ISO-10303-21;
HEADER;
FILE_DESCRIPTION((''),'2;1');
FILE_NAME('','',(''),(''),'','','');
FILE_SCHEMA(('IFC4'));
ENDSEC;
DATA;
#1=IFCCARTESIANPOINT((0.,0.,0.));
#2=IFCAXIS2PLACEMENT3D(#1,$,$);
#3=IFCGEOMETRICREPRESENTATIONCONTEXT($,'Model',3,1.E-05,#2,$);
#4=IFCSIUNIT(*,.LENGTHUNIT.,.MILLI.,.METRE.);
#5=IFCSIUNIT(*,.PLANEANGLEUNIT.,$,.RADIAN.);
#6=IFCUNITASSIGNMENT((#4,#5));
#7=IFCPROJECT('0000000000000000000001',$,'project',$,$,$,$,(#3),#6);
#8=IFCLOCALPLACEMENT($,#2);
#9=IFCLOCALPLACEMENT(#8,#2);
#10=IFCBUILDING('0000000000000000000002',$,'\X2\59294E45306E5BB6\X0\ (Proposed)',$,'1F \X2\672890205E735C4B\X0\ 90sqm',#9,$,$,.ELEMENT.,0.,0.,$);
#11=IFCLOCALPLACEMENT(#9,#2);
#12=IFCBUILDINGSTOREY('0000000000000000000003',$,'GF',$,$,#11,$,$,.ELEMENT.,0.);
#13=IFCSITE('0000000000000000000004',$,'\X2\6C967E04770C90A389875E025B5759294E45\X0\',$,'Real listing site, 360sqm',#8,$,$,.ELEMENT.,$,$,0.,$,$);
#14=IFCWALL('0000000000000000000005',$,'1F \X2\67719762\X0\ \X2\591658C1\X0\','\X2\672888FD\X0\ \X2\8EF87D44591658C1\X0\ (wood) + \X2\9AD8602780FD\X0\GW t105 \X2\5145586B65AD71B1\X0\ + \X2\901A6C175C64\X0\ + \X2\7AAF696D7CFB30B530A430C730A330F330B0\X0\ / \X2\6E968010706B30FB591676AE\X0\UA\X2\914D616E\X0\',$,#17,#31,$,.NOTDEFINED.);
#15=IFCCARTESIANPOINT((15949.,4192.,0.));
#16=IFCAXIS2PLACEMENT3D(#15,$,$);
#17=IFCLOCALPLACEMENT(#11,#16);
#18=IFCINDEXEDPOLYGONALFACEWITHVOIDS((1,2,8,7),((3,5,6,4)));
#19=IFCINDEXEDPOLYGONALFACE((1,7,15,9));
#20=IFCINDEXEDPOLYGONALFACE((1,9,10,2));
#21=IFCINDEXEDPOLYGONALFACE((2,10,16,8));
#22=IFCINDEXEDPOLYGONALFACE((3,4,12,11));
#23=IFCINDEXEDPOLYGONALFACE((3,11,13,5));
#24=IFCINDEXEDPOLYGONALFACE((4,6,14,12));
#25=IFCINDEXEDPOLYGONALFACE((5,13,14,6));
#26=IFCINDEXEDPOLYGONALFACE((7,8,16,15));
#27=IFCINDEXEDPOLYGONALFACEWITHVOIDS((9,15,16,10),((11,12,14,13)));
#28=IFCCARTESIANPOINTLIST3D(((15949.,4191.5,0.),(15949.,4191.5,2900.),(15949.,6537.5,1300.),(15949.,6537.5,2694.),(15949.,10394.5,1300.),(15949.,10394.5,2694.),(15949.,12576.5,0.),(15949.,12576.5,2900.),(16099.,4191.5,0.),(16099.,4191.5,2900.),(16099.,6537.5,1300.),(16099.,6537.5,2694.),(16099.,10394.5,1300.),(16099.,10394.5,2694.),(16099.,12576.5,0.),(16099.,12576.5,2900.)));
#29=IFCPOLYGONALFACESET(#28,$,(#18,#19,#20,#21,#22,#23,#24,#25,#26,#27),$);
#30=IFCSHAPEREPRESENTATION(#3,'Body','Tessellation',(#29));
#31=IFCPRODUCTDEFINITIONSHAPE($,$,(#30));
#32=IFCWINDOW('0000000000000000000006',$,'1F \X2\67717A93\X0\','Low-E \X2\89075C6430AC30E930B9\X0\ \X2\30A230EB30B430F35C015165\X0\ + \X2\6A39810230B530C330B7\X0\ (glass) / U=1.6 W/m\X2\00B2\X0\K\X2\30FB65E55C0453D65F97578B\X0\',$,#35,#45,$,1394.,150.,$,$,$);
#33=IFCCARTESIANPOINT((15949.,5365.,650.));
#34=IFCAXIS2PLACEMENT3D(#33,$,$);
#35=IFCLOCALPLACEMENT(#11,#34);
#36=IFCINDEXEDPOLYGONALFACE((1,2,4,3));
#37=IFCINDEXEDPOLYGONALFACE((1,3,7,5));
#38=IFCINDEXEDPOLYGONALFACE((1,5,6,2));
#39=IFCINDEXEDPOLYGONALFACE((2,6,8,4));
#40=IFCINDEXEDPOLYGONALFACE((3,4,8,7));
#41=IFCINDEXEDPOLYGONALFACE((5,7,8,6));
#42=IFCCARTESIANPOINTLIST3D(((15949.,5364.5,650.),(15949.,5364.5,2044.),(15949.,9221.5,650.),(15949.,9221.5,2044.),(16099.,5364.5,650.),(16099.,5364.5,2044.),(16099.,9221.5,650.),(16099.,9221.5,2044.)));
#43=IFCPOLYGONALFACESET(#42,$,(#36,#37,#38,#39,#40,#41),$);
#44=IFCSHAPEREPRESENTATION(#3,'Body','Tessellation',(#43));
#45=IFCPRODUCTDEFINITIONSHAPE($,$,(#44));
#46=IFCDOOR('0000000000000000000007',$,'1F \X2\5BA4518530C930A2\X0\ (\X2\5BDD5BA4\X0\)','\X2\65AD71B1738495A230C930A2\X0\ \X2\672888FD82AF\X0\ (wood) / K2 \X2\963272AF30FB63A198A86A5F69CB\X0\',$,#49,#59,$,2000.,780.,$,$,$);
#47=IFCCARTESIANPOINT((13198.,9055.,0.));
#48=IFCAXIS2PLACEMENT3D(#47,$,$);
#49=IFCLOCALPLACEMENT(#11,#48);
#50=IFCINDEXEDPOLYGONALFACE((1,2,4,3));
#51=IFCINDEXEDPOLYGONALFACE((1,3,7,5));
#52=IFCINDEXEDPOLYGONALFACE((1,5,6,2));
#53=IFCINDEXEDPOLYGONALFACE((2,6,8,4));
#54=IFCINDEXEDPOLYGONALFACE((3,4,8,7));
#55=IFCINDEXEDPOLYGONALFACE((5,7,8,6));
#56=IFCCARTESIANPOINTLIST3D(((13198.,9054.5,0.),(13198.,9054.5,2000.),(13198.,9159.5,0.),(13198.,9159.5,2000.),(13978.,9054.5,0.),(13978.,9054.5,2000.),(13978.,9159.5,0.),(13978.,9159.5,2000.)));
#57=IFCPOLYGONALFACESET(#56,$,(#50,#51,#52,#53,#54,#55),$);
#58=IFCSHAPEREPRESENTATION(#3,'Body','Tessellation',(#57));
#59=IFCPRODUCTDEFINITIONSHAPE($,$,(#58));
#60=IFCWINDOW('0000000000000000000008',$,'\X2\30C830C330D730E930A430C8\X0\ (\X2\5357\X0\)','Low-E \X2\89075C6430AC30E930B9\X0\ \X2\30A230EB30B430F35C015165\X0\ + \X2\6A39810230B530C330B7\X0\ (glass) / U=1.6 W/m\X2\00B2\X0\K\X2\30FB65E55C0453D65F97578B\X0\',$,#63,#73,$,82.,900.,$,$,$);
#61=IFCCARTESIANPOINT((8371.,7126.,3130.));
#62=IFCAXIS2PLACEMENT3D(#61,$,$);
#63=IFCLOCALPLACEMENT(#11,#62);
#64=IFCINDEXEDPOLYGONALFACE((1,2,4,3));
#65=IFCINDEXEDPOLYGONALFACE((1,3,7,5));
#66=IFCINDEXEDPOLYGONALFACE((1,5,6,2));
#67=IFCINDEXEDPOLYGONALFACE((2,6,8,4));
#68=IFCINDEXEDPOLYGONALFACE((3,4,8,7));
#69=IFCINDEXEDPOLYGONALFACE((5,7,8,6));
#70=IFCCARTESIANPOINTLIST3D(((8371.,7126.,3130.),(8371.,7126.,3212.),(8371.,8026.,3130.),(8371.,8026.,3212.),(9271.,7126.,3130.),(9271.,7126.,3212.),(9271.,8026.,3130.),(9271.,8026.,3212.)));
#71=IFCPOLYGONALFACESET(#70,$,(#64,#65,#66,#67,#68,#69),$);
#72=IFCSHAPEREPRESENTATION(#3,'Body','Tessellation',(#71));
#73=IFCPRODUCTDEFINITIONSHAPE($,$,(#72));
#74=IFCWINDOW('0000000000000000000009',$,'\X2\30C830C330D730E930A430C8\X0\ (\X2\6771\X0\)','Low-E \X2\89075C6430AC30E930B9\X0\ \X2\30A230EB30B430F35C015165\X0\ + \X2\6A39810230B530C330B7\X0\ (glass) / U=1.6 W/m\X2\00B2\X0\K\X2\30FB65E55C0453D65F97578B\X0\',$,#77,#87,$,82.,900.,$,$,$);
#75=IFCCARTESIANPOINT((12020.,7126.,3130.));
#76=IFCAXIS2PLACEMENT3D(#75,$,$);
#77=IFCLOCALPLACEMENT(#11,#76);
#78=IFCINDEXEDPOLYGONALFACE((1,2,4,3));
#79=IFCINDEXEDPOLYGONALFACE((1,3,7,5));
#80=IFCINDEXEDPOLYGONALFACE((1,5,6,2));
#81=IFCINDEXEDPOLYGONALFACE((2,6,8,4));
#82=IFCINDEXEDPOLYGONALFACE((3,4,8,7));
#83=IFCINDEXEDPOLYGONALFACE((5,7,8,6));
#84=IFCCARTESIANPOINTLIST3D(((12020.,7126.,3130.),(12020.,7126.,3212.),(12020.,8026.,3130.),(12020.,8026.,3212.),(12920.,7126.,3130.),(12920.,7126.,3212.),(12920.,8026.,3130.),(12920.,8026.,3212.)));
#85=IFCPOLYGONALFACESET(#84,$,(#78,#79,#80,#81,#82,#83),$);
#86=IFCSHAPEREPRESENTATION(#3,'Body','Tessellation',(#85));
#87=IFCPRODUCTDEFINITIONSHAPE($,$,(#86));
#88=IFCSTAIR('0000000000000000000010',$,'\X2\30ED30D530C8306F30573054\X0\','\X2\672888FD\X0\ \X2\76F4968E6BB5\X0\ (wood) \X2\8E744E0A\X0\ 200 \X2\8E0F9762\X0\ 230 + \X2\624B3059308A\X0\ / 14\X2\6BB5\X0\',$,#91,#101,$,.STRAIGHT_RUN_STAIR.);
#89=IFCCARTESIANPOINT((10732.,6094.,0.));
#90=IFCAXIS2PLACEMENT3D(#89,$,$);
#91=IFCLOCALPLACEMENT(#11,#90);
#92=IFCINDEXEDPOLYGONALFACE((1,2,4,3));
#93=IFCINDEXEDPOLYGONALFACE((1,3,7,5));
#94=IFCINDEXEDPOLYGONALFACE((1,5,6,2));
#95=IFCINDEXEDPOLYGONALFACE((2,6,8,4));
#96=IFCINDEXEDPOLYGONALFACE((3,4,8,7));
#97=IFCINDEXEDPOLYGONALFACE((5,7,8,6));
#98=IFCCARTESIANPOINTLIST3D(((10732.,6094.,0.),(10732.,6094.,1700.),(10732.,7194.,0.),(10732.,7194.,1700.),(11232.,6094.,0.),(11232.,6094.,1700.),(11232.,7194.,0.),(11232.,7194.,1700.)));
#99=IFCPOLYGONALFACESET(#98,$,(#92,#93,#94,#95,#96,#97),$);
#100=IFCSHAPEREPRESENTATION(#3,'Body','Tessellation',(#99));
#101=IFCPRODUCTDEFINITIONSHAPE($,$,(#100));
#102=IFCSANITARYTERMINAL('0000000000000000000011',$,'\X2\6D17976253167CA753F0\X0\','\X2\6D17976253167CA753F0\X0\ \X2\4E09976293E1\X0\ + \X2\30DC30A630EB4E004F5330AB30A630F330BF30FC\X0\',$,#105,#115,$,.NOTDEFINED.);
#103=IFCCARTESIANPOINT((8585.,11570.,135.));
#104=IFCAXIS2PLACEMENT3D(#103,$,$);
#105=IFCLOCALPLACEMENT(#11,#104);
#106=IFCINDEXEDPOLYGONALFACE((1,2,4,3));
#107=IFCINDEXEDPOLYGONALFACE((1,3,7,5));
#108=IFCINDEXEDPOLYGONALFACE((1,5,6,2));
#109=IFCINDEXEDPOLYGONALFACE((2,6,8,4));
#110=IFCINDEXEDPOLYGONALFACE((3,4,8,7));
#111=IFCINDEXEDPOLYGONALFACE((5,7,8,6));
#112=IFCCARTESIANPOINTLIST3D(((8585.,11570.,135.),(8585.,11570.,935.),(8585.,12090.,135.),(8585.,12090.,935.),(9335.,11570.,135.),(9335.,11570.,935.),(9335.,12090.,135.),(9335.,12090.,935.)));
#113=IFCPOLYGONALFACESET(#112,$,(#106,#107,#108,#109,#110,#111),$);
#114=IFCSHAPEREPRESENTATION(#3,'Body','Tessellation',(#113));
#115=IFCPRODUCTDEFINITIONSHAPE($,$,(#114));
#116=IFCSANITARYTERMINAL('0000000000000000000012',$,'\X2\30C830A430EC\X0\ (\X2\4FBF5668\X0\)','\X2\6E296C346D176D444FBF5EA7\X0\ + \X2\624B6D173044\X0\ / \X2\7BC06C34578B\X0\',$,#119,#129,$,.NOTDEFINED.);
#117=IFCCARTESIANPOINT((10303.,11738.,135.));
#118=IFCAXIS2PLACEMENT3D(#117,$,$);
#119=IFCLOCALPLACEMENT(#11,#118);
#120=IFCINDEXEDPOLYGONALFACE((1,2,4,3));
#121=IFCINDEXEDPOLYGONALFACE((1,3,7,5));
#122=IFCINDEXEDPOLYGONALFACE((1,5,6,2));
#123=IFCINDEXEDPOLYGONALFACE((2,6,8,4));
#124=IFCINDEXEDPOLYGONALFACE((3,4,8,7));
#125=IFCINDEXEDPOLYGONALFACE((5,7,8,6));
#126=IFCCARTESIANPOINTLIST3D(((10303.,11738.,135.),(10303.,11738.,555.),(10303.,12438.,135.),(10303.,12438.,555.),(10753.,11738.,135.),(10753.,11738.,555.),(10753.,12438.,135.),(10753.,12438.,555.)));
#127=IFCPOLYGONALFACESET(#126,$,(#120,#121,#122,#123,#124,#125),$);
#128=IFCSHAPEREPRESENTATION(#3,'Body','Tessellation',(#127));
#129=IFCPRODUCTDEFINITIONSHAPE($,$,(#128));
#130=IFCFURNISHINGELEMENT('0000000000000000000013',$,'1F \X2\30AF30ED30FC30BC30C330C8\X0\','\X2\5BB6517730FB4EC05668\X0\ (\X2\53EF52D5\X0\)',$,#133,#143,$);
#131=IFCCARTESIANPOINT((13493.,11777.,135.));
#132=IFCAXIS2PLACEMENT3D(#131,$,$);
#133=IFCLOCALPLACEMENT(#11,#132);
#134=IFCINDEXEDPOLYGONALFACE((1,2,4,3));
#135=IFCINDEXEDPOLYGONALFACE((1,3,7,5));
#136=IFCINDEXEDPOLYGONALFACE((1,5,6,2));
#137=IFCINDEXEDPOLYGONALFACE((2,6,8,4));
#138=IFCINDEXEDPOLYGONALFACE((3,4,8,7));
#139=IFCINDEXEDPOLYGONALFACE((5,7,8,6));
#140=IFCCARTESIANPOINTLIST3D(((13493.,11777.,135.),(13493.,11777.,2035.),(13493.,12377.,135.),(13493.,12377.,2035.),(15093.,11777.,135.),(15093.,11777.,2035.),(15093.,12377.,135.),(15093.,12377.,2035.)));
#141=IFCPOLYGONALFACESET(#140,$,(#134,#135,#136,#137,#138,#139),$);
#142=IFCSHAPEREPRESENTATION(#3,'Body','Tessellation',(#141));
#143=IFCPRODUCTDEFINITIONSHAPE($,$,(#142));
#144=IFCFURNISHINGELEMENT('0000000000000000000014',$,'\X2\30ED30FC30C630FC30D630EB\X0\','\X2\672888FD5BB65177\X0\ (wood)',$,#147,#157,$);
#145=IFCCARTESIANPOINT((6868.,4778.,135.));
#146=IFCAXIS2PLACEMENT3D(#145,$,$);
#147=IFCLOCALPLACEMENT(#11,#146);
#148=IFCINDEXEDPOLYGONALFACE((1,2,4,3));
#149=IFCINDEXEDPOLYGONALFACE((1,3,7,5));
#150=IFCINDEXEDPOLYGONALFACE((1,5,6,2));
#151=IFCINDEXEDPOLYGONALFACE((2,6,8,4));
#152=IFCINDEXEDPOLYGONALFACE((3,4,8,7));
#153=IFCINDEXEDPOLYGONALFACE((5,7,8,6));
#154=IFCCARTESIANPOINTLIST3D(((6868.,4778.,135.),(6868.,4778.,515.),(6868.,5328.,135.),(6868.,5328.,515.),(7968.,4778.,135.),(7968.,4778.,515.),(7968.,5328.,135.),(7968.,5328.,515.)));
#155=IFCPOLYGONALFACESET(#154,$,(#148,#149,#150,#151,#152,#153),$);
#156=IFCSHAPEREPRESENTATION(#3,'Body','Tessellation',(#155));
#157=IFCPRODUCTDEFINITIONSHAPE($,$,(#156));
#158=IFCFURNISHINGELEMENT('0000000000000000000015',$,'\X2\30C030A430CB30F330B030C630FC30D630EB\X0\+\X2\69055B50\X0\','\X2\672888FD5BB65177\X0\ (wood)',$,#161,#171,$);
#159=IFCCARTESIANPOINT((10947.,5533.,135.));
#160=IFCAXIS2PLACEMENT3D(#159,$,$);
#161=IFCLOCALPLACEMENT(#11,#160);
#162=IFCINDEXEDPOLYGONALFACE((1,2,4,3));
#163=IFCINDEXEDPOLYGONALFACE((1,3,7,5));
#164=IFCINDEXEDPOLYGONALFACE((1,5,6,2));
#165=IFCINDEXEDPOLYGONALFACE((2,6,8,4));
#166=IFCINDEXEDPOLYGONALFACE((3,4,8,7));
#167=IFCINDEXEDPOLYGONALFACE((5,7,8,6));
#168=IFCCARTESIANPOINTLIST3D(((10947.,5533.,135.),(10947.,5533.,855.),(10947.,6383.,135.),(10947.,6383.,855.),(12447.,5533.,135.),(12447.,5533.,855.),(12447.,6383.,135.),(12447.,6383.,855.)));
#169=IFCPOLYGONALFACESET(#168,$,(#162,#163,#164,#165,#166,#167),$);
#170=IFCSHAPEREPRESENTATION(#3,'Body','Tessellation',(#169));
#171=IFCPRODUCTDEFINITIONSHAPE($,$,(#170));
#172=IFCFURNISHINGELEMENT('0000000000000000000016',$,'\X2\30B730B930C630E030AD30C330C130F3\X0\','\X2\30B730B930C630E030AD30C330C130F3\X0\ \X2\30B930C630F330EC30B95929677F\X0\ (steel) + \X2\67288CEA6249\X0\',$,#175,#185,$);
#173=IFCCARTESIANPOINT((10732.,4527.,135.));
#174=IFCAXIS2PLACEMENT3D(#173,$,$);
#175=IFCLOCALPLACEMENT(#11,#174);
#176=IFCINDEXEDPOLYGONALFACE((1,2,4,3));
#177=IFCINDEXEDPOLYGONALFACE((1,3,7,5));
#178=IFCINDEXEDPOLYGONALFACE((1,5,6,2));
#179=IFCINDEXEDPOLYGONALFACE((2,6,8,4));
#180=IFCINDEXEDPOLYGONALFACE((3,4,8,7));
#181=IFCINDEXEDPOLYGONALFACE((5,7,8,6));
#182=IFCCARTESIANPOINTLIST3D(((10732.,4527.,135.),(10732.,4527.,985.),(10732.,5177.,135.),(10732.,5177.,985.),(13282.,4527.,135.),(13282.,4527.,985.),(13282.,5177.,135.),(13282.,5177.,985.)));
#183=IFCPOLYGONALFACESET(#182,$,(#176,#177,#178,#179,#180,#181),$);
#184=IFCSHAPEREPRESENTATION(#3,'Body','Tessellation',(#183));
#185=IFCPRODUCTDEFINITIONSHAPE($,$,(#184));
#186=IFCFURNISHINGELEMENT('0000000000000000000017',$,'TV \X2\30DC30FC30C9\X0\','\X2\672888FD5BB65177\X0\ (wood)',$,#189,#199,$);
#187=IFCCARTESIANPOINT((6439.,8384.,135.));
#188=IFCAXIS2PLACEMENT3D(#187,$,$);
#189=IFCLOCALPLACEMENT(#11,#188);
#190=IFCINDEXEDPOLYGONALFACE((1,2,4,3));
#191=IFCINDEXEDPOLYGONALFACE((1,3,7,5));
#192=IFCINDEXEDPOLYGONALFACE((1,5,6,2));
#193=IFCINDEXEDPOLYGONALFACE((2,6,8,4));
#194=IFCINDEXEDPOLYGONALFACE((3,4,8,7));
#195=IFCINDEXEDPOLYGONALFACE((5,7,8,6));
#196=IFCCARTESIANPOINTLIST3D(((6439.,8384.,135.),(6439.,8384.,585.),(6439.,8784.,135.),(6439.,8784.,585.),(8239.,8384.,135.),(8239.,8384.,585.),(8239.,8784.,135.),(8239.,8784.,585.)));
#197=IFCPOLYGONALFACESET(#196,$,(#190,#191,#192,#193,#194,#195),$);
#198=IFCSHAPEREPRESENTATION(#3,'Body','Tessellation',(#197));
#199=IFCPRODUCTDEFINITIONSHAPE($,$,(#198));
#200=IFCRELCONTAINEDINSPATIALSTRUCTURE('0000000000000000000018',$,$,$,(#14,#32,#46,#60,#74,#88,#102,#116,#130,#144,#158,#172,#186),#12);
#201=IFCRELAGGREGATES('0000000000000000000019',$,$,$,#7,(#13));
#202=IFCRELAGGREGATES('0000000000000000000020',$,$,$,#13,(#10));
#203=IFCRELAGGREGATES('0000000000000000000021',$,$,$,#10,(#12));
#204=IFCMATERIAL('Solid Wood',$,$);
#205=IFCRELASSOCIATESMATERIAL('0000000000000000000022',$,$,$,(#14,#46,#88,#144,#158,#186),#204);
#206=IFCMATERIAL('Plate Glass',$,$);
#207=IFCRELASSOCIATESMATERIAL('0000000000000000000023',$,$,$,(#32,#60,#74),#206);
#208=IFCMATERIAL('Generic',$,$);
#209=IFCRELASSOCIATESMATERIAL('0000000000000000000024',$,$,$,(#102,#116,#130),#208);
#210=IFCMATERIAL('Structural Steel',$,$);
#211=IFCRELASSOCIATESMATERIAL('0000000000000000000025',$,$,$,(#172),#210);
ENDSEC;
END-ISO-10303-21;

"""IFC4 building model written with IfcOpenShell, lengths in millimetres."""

from ifc_helpers import new_model, si_unit, frame, frame_2d, origin, place, context, project, spatial, rectangle, extrude, material, element, fill, save


model = new_model("IFC4")

# Units and contexts
model_context = context("Model", 3, precision=1e-05, world=origin())
ifc_project = project(units=[si_unit("LENGTHUNIT", "METRE", prefix="MILLI"), si_unit("PLANEANGLEUNIT", "RADIAN")], contexts=[model_context])

# Site, building, storey
site_placement = place(None, origin())
site = spatial("IfcSite", under=ifc_project, at=site_placement, Name="沖縄県那覇市字天久", ObjectType="Real listing site, 360sqm", CompositionType="ELEMENT", RefElevation=0.0)
building_placement = place(site_placement, origin())
building = spatial("IfcBuilding", under=site, at=building_placement, Name="天久の家 (Proposed)", ObjectType="1F 木造平屋 90sqm", CompositionType="ELEMENT", ElevationOfRefHeight=0.0, ElevationOfTerrain=0.0)
storey_placement = place(building_placement, origin())
storey = spatial("IfcBuildingStorey", under=building, at=storey_placement, Name="GF", CompositionType="ELEMENT", Elevation=0.0)

# Wall, opening, window
ifc_material_1 = material(Name="Solid Wood")
wall_1_placement = place(storey_placement, frame((15949.0, 4192.0, 0.0)))
wall_1 = element("IfcWall", 1, at=wall_1_placement, inside=storey, material=ifc_material_1, Name="1F 東面 外壁", Description="木製 軸組外壁 (wood) + 高性能GW t105 充填断熱 + 通気層 + 窯業系サイディング / 準耐火・外皮UA配慮", PredefinedType="NOTDEFINED", context=model_context, shape_type="SweptSolid", body=[
    extrude(rectangle(XDim=150.0, YDim=8385.0, at=frame_2d((75.0, 4192.0))), frame((15949.0, 4192.0, 0.0)), (0.0, 0.0, 1.0), 2900.0),
])
opening_placement = place(storey_placement, frame((15949.0, 5365.0, 650.0)))
opening = element("IfcOpeningElement", 2, at=opening_placement, cuts=wall_1, PredefinedType="NOTDEFINED", context=model_context, shape_type="SweptSolid", body=[
    extrude(rectangle(XDim=150.0, YDim=3857.0, at=frame_2d((75.0, 1928.0))), frame((15949.0, 5365.0, 650.0)), (0.0, 0.0, 1.0), 1394.0),
])
ifc_material_2 = material(Name="Plate Glass")
window_1_placement = place(storey_placement, frame((15949.0, 5365.0, 650.0)))
window_1 = element("IfcWindow", 3, at=window_1_placement, inside=storey, material=ifc_material_2, Name="1F 東窓", Description="Low-E 複層ガラス アルゴン封入 + 樹脂サッシ (glass) / U=1.6 W/m²K・日射取得型", OverallHeight=1394.0, OverallWidth=150.0, context=model_context, shape_type="SweptSolid", body=[
    extrude(rectangle(XDim=150.0, YDim=3857.0, at=frame_2d((75.0, 1928.0))), frame((15949.0, 5365.0, 650.0)), (0.0, 0.0, 1.0), 1394.0),
])
fill(opening, window_1)

# Door
door_placement = place(storey_placement, frame((13198.0, 9055.0, 0.0)))
element("IfcDoor", 4, at=door_placement, inside=storey, material=ifc_material_1, Name="1F 室内ドア (寝室)", Description="断熱玄関ドア 木製芯 (wood) / K2 防犯・採風機構", OverallHeight=2000.0, OverallWidth=780.0, context=model_context, shape_type="SweptSolid", body=[
    extrude(rectangle(XDim=780.0, YDim=105.0, at=frame_2d((390.0, 52.0))), frame((13198.0, 9055.0, 0.0)), (0.0, 0.0, 1.0), 2000.0),
])

# Windows
window_2_placement = place(storey_placement, frame((8371.0, 7126.0, 3130.0)))
element("IfcWindow", 5, at=window_2_placement, inside=storey, material=ifc_material_2, Name="トップライト (南)", Description="Low-E 複層ガラス アルゴン封入 + 樹脂サッシ (glass) / U=1.6 W/m²K・日射取得型", OverallHeight=82.0, OverallWidth=900.0, context=model_context, shape_type="SweptSolid", body=[
    extrude(rectangle(XDim=900.0, YDim=900.0, at=frame_2d((450.0, 450.0))), frame((8371.0, 7126.0, 3130.0)), (0.0, 0.0, 1.0), 82.0),
])
window_3_placement = place(storey_placement, frame((12020.0, 7126.0, 3130.0)))
element("IfcWindow", 6, at=window_3_placement, inside=storey, material=ifc_material_2, Name="トップライト (東)", Description="Low-E 複層ガラス アルゴン封入 + 樹脂サッシ (glass) / U=1.6 W/m²K・日射取得型", OverallHeight=82.0, OverallWidth=900.0, context=model_context, shape_type="SweptSolid", body=[
    extrude(rectangle(XDim=900.0, YDim=900.0, at=frame_2d((450.0, 450.0))), frame((12020.0, 7126.0, 3130.0)), (0.0, 0.0, 1.0), 82.0),
])

# Stair
stair_placement = place(storey_placement, frame((10732.0, 6094.0, 0.0)))
element("IfcStair", 7, at=stair_placement, inside=storey, material=ifc_material_1, Name="ロフトはしご", Description="木製 直階段 (wood) 蹴上 200 踏面 230 + 手すり / 14段", PredefinedType="STRAIGHT_RUN_STAIR", context=model_context, shape_type="SweptSolid", body=[
    extrude(rectangle(XDim=500.0, YDim=1100.0, at=frame_2d((250.0, 550.0))), frame((10732.0, 6094.0, 0.0)), (0.0, 0.0, 1.0), 1700.0),
])

# Sanitary terminals
ifc_material_3 = material(Name="Generic")
sanitary_terminal_1_placement = place(storey_placement, frame((8585.0, 11570.0, 135.0)))
element("IfcSanitaryTerminal", 8, at=sanitary_terminal_1_placement, inside=storey, material=ifc_material_3, Name="洗面化粧台", Description="洗面化粧台 三面鏡 + ボウル一体カウンター", PredefinedType="NOTDEFINED", context=model_context, shape_type="SweptSolid", body=[
    extrude(rectangle(XDim=750.0, YDim=520.0, at=frame_2d((375.0, 260.0))), frame((8585.0, 11570.0, 135.0)), (0.0, 0.0, 1.0), 800.0),
])
sanitary_terminal_2_placement = place(storey_placement, frame((10303.0, 11738.0, 135.0)))
element("IfcSanitaryTerminal", 9, at=sanitary_terminal_2_placement, inside=storey, material=ifc_material_3, Name="トイレ (便器)", Description="温水洗浄便座 + 手洗い / 節水型", PredefinedType="NOTDEFINED", context=model_context, shape_type="SweptSolid", body=[
    extrude(rectangle(XDim=450.0, YDim=700.0, at=frame_2d((225.0, 350.0))), frame((10303.0, 11738.0, 135.0)), (0.0, 0.0, 1.0), 420.0),
])

# Furnishing elements
furnishing_1_placement = place(storey_placement, frame((13493.0, 11777.0, 135.0)))
element("IfcFurnishingElement", 10, at=furnishing_1_placement, inside=storey, material=ifc_material_3, Name="1F クローゼット", Description="家具・什器 (可動)", context=model_context, shape_type="SweptSolid", body=[
    extrude(rectangle(XDim=1600.0, YDim=600.0, at=frame_2d((800.0, 300.0))), frame((13493.0, 11777.0, 135.0)), (0.0, 0.0, 1.0), 1900.0),
])
furnishing_2_placement = place(storey_placement, frame((6868.0, 4778.0, 135.0)))
element("IfcFurnishingElement", 11, at=furnishing_2_placement, inside=storey, material=ifc_material_1, Name="ローテーブル", Description="木製家具 (wood)", context=model_context, shape_type="SweptSolid", body=[
    extrude(rectangle(XDim=1100.0, YDim=550.0, at=frame_2d((550.0, 275.0))), frame((6868.0, 4778.0, 135.0)), (0.0, 0.0, 1.0), 380.0),
])
furnishing_3_placement = place(storey_placement, frame((10947.0, 5533.0, 135.0)))
element("IfcFurnishingElement", 12, at=furnishing_3_placement, inside=storey, material=ifc_material_1, Name="ダイニングテーブル+椅子", Description="木製家具 (wood)", context=model_context, shape_type="SweptSolid", body=[
    extrude(rectangle(XDim=1500.0, YDim=850.0, at=frame_2d((750.0, 425.0))), frame((10947.0, 5533.0, 135.0)), (0.0, 0.0, 1.0), 720.0),
])
ifc_material_4 = material(Name="Structural Steel")
furnishing_4_placement = place(storey_placement, frame((10732.0, 4527.0, 135.0)))
element("IfcFurnishingElement", 13, at=furnishing_4_placement, inside=storey, material=ifc_material_4, Name="システムキッチン", Description="システムキッチン ステンレス天板 (steel) + 木質扉", context=model_context, shape_type="SweptSolid", body=[
    extrude(rectangle(XDim=2550.0, YDim=650.0, at=frame_2d((1275.0, 325.0))), frame((10732.0, 4527.0, 135.0)), (0.0, 0.0, 1.0), 850.0),
])
furnishing_5_placement = place(storey_placement, frame((6439.0, 8384.0, 135.0)))
element("IfcFurnishingElement", 14, at=furnishing_5_placement, inside=storey, material=ifc_material_1, Name="TV ボード", Description="木製家具 (wood)", context=model_context, shape_type="SweptSolid", body=[
    extrude(rectangle(XDim=1800.0, YDim=400.0, at=frame_2d((900.0, 200.0))), frame((6439.0, 8384.0, 135.0)), (0.0, 0.0, 1.0), 450.0),
])

save(model, "model.ifc")
